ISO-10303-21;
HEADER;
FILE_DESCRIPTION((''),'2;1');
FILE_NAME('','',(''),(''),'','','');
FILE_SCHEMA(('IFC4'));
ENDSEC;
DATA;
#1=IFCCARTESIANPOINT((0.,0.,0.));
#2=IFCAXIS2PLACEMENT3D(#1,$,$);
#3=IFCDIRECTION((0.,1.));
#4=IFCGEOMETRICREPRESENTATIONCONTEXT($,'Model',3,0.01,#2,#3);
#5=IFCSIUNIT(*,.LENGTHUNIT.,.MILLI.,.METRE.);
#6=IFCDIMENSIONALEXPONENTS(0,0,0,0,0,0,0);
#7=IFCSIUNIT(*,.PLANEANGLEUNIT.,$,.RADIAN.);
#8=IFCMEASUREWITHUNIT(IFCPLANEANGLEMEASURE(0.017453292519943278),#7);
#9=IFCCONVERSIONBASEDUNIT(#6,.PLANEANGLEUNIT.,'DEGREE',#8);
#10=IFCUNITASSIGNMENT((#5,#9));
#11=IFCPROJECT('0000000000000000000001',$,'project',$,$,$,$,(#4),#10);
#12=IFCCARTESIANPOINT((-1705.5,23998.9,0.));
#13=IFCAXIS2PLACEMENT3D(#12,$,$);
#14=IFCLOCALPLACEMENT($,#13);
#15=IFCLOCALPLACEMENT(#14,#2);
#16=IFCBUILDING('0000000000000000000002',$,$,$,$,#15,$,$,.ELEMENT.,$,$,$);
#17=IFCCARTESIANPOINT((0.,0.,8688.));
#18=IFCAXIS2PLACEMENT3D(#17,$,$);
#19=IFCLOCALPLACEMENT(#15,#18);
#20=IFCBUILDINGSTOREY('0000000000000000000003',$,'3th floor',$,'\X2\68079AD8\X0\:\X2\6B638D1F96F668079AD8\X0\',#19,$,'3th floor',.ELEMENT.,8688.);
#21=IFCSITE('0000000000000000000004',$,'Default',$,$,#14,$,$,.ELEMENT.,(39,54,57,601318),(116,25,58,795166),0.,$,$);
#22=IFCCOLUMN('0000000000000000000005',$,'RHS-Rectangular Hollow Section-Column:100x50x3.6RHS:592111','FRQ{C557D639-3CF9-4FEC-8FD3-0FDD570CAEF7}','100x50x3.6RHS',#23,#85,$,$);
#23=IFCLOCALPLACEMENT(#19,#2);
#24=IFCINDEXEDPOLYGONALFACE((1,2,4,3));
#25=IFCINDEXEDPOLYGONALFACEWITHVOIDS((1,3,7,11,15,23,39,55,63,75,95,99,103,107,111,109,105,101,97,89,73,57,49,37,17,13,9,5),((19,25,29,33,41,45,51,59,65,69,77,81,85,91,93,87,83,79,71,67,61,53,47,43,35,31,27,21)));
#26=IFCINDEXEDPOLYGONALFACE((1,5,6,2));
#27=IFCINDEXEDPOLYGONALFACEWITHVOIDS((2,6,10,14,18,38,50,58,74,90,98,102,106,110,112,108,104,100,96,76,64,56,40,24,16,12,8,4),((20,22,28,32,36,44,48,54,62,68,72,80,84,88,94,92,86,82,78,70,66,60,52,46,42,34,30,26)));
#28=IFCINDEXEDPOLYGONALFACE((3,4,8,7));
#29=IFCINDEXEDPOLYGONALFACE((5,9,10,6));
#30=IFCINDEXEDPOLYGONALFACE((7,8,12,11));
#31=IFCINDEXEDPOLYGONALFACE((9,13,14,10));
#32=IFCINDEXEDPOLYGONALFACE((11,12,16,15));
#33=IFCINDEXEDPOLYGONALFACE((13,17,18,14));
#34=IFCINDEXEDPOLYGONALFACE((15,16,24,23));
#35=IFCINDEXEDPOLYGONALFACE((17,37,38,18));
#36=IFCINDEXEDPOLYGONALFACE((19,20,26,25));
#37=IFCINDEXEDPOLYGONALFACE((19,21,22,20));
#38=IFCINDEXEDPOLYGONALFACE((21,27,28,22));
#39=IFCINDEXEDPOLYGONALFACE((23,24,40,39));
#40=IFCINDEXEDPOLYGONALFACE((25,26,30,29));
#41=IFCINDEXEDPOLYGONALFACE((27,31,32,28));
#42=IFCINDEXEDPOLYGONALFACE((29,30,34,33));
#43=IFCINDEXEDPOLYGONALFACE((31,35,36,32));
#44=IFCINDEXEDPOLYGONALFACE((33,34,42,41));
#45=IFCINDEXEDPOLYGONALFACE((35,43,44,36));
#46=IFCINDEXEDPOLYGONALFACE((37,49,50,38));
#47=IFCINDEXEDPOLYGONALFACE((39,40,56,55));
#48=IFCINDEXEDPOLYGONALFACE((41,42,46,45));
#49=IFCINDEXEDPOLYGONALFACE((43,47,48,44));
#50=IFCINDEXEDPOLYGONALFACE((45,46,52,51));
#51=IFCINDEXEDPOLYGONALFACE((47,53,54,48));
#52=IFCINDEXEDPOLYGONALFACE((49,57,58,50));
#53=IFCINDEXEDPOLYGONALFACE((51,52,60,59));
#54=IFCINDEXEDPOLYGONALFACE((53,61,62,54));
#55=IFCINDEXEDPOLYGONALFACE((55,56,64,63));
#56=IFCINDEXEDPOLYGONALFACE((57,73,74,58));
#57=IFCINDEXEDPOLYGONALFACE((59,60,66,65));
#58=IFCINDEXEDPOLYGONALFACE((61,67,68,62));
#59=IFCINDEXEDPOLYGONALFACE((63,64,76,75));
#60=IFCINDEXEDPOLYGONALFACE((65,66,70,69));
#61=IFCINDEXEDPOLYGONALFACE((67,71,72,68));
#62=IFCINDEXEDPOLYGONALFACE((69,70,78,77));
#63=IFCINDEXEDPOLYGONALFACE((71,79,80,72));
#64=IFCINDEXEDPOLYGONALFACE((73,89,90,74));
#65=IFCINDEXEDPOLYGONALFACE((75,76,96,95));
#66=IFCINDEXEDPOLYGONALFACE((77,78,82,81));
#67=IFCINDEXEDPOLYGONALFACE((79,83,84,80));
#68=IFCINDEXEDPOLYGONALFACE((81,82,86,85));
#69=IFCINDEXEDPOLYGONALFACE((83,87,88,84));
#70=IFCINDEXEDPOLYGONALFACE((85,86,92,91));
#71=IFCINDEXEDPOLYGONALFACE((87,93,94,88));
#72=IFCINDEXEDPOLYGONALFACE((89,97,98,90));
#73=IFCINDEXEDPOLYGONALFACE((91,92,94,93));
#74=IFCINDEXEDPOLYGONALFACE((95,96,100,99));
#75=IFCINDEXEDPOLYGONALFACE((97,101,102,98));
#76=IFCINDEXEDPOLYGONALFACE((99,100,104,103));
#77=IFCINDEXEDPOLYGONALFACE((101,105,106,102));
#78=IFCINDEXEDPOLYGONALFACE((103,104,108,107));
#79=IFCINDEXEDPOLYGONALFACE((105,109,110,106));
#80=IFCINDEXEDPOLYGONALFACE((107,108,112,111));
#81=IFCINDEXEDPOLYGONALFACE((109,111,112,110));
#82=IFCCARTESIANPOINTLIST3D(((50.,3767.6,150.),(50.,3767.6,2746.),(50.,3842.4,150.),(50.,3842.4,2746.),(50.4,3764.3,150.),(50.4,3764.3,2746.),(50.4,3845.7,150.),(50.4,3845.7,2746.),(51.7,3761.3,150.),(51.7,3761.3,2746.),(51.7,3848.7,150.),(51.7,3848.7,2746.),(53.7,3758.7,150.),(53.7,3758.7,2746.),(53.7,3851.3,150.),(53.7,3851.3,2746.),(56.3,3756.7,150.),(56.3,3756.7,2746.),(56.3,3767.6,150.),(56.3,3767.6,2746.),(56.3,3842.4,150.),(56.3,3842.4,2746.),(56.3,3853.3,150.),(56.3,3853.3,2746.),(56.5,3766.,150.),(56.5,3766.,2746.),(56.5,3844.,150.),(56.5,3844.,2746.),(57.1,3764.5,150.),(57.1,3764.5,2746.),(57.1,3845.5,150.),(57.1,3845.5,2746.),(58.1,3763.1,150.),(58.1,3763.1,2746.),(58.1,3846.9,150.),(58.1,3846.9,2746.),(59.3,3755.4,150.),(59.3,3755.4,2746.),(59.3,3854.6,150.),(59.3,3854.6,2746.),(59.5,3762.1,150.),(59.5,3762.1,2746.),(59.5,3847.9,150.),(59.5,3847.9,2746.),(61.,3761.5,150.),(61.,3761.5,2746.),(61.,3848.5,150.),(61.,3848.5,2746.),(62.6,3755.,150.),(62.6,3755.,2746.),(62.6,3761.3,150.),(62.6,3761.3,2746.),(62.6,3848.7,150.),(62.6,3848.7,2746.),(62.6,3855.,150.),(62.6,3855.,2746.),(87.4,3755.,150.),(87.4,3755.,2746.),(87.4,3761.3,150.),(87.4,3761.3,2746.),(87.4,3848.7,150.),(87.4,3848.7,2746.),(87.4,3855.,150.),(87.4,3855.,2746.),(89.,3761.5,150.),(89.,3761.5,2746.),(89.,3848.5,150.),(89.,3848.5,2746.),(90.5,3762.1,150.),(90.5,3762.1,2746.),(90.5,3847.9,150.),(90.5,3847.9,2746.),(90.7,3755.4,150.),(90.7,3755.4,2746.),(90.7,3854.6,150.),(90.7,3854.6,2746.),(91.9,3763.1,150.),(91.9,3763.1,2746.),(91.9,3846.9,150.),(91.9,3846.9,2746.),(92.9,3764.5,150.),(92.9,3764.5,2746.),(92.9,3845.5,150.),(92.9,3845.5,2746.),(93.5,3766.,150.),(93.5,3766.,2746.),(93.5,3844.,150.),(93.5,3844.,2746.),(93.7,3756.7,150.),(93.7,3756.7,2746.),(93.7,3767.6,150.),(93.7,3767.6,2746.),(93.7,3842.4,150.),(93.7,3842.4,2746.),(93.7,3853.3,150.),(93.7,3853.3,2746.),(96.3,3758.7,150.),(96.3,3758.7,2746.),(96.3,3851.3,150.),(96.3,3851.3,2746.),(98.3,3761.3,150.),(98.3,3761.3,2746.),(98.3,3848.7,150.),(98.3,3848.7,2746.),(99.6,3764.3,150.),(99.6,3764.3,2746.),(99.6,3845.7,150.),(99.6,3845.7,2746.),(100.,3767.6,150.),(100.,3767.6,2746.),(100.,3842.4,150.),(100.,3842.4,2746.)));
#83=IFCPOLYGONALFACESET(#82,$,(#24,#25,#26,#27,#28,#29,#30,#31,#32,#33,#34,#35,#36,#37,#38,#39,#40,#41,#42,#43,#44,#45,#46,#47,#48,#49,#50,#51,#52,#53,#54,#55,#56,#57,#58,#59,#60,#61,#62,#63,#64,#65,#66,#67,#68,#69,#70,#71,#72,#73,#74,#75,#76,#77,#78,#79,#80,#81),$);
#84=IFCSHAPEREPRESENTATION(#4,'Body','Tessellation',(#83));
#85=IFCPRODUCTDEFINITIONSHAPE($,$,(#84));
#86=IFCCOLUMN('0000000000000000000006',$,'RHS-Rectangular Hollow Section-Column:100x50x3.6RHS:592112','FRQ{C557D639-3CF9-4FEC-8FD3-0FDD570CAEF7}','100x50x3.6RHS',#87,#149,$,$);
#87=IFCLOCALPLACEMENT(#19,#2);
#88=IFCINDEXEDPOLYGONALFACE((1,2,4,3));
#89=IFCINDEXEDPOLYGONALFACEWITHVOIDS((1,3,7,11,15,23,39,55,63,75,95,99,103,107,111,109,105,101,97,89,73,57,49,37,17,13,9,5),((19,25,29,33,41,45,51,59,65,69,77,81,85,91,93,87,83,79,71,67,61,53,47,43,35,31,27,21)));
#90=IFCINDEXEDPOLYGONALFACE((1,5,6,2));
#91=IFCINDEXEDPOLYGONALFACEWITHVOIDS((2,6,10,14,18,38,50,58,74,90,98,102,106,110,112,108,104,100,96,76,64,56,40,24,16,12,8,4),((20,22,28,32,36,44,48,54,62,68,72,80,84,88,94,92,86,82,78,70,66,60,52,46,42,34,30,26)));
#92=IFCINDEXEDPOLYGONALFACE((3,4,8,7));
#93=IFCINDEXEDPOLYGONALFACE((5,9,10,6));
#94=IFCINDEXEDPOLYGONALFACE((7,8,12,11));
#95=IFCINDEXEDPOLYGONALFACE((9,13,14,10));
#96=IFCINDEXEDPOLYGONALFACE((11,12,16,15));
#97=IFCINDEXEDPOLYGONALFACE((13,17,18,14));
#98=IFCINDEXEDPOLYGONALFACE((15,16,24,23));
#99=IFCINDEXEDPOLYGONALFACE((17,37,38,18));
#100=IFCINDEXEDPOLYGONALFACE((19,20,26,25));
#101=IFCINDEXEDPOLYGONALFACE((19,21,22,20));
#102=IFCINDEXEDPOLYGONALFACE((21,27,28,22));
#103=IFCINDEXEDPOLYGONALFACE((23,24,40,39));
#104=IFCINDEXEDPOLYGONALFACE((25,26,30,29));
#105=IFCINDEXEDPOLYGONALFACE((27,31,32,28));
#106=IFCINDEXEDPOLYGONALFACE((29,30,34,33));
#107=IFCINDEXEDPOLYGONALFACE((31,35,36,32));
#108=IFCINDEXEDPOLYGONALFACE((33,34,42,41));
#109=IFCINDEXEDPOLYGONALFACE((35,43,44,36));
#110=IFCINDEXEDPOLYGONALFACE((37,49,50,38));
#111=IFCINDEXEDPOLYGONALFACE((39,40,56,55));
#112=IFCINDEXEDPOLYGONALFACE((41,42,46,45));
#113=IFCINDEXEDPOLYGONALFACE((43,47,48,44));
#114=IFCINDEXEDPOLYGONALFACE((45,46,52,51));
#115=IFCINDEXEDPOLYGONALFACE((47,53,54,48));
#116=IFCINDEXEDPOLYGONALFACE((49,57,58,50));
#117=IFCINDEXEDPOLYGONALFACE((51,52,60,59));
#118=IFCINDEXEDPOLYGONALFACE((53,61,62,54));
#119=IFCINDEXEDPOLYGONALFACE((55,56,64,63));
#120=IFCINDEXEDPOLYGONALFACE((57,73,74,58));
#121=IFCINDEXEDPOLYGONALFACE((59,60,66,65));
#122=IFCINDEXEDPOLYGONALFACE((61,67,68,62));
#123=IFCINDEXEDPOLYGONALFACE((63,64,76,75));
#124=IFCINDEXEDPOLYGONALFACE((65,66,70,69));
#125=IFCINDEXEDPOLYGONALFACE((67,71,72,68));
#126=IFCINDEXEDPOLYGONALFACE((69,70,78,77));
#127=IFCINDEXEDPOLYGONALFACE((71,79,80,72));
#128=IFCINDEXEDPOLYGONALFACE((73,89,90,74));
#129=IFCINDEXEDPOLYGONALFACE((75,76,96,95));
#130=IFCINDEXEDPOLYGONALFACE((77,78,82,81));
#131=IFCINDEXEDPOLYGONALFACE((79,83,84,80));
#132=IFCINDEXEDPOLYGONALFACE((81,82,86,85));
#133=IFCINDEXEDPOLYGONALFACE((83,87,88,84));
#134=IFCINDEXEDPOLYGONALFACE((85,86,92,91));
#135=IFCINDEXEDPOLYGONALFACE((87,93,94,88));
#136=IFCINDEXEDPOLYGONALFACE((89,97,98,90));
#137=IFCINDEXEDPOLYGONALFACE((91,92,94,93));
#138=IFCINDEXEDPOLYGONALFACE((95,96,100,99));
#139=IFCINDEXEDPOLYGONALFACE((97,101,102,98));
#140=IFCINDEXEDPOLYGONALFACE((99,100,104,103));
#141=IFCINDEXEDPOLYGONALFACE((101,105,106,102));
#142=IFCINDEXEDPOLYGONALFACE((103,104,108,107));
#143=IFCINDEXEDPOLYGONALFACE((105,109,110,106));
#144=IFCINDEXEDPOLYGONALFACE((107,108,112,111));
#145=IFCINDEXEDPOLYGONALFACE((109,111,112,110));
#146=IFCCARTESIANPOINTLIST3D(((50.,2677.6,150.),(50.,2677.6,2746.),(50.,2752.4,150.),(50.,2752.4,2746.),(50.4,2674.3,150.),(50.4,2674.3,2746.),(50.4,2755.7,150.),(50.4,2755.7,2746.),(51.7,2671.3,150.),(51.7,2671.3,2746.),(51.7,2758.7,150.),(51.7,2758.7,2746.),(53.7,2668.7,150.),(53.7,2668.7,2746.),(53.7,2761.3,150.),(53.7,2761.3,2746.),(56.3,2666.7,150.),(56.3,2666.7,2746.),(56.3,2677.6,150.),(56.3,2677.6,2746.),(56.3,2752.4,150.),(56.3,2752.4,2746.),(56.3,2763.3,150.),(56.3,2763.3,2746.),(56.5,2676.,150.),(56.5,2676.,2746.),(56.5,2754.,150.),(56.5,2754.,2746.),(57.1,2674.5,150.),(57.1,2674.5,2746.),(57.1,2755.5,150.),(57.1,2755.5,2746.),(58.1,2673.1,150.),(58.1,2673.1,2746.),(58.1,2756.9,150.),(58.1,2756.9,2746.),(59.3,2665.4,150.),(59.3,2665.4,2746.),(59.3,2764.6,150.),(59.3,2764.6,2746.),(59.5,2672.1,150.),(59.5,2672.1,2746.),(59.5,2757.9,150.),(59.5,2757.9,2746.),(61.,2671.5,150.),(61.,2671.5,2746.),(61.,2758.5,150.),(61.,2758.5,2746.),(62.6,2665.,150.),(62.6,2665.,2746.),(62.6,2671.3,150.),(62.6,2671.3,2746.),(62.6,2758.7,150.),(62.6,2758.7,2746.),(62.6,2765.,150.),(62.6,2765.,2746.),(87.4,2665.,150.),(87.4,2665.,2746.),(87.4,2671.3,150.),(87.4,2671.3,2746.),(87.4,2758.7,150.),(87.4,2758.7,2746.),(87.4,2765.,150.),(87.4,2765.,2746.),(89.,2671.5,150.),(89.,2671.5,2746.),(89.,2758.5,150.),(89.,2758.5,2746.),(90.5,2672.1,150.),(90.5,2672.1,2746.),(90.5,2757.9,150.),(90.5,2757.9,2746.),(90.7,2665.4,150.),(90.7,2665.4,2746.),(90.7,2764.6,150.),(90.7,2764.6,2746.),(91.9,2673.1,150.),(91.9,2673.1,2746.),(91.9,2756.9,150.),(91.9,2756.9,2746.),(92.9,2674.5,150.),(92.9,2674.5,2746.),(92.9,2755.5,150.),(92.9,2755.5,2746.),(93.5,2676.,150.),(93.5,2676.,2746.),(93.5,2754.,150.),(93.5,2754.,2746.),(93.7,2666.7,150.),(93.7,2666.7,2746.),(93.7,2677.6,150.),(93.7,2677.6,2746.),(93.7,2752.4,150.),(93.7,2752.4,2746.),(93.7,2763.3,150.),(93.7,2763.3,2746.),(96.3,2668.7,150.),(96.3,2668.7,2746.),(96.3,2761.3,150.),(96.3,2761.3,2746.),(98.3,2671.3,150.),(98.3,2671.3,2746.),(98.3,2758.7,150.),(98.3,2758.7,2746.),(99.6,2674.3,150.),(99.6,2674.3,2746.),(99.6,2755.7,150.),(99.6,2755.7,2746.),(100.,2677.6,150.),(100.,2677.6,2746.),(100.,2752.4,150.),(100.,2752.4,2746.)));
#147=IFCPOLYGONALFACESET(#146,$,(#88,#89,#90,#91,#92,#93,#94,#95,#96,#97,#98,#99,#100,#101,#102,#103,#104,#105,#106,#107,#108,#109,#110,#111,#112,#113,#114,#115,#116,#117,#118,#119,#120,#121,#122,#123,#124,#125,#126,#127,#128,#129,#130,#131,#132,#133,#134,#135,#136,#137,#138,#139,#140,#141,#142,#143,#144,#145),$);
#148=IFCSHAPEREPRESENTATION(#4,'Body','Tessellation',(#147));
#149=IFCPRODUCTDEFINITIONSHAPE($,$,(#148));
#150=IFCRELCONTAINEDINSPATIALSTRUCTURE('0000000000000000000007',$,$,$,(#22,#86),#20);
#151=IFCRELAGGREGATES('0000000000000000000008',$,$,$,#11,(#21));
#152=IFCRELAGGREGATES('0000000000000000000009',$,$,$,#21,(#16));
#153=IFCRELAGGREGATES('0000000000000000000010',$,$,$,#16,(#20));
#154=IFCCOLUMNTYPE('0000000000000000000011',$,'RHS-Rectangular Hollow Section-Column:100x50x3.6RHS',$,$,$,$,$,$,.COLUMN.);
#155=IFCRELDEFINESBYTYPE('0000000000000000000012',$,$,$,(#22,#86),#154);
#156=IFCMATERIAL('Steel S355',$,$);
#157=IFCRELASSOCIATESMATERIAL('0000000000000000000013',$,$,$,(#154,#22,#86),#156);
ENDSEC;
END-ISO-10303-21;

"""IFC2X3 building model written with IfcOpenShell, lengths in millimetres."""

from ifc_helpers import new_model, entity, si_unit, converted_unit, point, direction, frame, frame_2d, origin, origin_2d, place, context, project, spatial, circle_curve, line_curve, trimmed, segment, composite_curve, hollow_rectangle, outline, extrude, clip, halfspace, material, type_object, element, save


model = new_model("IFC2X3")

# Units and contexts
model_context = context("Model", 3, precision=0.01, world=origin(), true_north=direction((0.0, 1.0)))
ifc_project = project(units=[si_unit("LENGTHUNIT", "METRE", prefix="MILLI"), converted_unit("PLANEANGLEUNIT", "DEGREE", entity("IfcPlaneAngleMeasure", 0.017453292519943278), si_unit("PLANEANGLEUNIT", "RADIAN"), dimensions=[0, 0, 0, 0, 0, 0, 0])], contexts=[model_context])

# Site, building, storey
site_placement = place(None, frame((-1705.5, 23998.9, 0.0)))
site = spatial("IfcSite", under=ifc_project, at=site_placement, Name="Default", CompositionType="ELEMENT", RefLatitude=(39, 54, 57, 601318), RefLongitude=(116, 25, 58, 795166), RefElevation=0.0)
building_placement = place(site_placement, origin())
building = spatial("IfcBuilding", under=site, at=building_placement, CompositionType="ELEMENT")
storey_placement = place(building_placement, frame((0.0, 0.0, 8688.0)))
storey = spatial("IfcBuildingStorey", under=building, at=storey_placement, Name="3th floor", ObjectType="标高:正负零标高", LongName="3th floor", CompositionType="ELEMENT", Elevation=8688.0)

# Columns, openings
ifc_material_1 = material(Name="Steel S355")
column_type_1 = type_object("IfcColumnType", Name="RHS-Rectangular Hollow Section-Column:100x50x3.6RHS", PredefinedType="COLUMN", material=ifc_material_1)
column_1_placement = place(storey_placement, frame((75.0, 3805.0, 2876.9)))
column_1 = element("IfcColumn", 1, at=column_1_placement, inside=storey, type_object=column_type_1, material=ifc_material_1, Name="RHS-Rectangular Hollow Section-Column:100x50x3.6RHS:592111", Description="FRQ{C557D639-3CF9-4FEC-8FD3-0FDD570CAEF7}", ObjectType="100x50x3.6RHS", context=model_context, shape_type="Clipping", body=[
    clip(clip(extrude(hollow_rectangle(XDim=50.0, YDim=100.0, WallThickness=6.3, InnerFilletRadius=6.3, OuterFilletRadius=12.6, at=origin_2d()), origin(), (0.0, 0.0, -1.0), 2782.8), halfspace(frame((-75.0, -3805.0, -55.9), z_axis=(0.0, 0.0, -1.0), x_axis=(-1.0, 0.0, 0.0)), True)), halfspace(frame((-75.0, -3805.0, -2726.9), z_axis=(0.0, 0.0, 1.0), x_axis=(1.0, 0.0, 0.0)), True)),
])
opening_1_placement = place(column_1_placement, frame((0.0, -150.1, -130.9), z_axis=(0.0, 1.0, 0.0), x_axis=(-1.0, 0.0, 0.0)))
element("IfcOpeningElement", 2, at=opening_1_placement, cuts=column_1, ObjectType="Opening", context=model_context, shape_type="SweptSolid", body=[
    extrude(outline(composite_curve([segment(trimmed(circle_curve(frame_2d((43.0, 32.0), x_axis=(1.0, 0.0)), 32.0), [point((43.0, 0.0))], [point((75.0, 32.0))], True, "CARTESIAN"), True, "CONTINUOUS"), segment(trimmed(line_curve((75.0, 32.0), (0.0, 1.0), 86.0), [point((75.0, 32.0))], [point((75.0, 118.0))], True, "CARTESIAN"), True, "CONTINUOUS"), segment(trimmed(circle_curve(frame_2d((43.0, 118.0), x_axis=(1.0, 0.0)), 32.0), [point((75.0, 118.0))], [point((43.0, 150.0))], True, "CARTESIAN"), True, "CONTINUOUS"), segment(trimmed(line_curve((43.0, 150.0), (-1.0, 0.0), 86.0), [point((43.0, 150.0))], [point((-43.0, 150.0))], True, "CARTESIAN"), True, "CONTINUOUS"), segment(trimmed(circle_curve(frame_2d((-43.0, 118.0), x_axis=(1.0, 0.0)), 32.0), [point((-43.0, 150.0))], [point((-75.0, 118.0))], True, "CARTESIAN"), True, "CONTINUOUS"), segment(trimmed(line_curve((-75.0, 118.0), (0.0, -1.0), 86.0), [point((-75.0, 118.0))], [point((-75.0, 32.0))], True, "CARTESIAN"), True, "CONTINUOUS"), segment(trimmed(circle_curve(frame_2d((-43.0, 32.0), x_axis=(1.0, 0.0)), 32.0), [point((-75.0, 32.0))], [point((-43.0, 0.0))], True, "CARTESIAN"), True, "CONTINUOUS"), segment(trimmed(line_curve((-43.0, 0.0), (1.0, 0.0), 86.0), [point((-43.0, 0.0))], [point((43.0, 0.0))], True, "CARTESIAN"), True, "CONTINUOUS")], self_intersect="UNKNOWN")), origin(), (0.0, 0.0, 1.0), 300.2),
])
column_2_placement = place(storey_placement, frame((75.0, 2715.0, 2876.9)))
column_2 = element("IfcColumn", 3, at=column_2_placement, inside=storey, type_object=column_type_1, material=ifc_material_1, Name="RHS-Rectangular Hollow Section-Column:100x50x3.6RHS:592112", Description="FRQ{C557D639-3CF9-4FEC-8FD3-0FDD570CAEF7}", ObjectType="100x50x3.6RHS", context=model_context, shape_type="Clipping", body=[
    clip(clip(extrude(hollow_rectangle(XDim=50.0, YDim=100.0, WallThickness=6.3, InnerFilletRadius=6.3, OuterFilletRadius=12.6, at=origin_2d()), origin(), (0.0, 0.0, -1.0), 2782.8), halfspace(frame((-75.0, -2715.0, -55.9), z_axis=(0.0, 0.0, -1.0), x_axis=(-1.0, 0.0, 0.0)), True)), halfspace(frame((-75.0, -2715.0, -2726.9), z_axis=(0.0, 0.0, 1.0), x_axis=(1.0, 0.0, 0.0)), True)),
])
opening_2_placement = place(column_2_placement, frame((0.0, -150.1, -130.9), z_axis=(0.0, 1.0, 0.0), x_axis=(-1.0, 0.0, 0.0)))
element("IfcOpeningElement", 4, at=opening_2_placement, cuts=column_2, ObjectType="Opening", context=model_context, shape_type="SweptSolid", body=[
    extrude(outline(composite_curve([segment(trimmed(circle_curve(frame_2d((43.0, 32.0), x_axis=(1.0, 0.0)), 32.0), [point((43.0, 0.0))], [point((75.0, 32.0))], True, "CARTESIAN"), True, "CONTINUOUS"), segment(trimmed(line_curve((75.0, 32.0), (0.0, 1.0), 86.0), [point((75.0, 32.0))], [point((75.0, 118.0))], True, "CARTESIAN"), True, "CONTINUOUS"), segment(trimmed(circle_curve(frame_2d((43.0, 118.0), x_axis=(1.0, 0.0)), 32.0), [point((75.0, 118.0))], [point((43.0, 150.0))], True, "CARTESIAN"), True, "CONTINUOUS"), segment(trimmed(line_curve((43.0, 150.0), (-1.0, 0.0), 86.0), [point((43.0, 150.0))], [point((-43.0, 150.0))], True, "CARTESIAN"), True, "CONTINUOUS"), segment(trimmed(circle_curve(frame_2d((-43.0, 118.0), x_axis=(1.0, 0.0)), 32.0), [point((-43.0, 150.0))], [point((-75.0, 118.0))], True, "CARTESIAN"), True, "CONTINUOUS"), segment(trimmed(line_curve((-75.0, 118.0), (0.0, -1.0), 86.0), [point((-75.0, 118.0))], [point((-75.0, 32.0))], True, "CARTESIAN"), True, "CONTINUOUS"), segment(trimmed(circle_curve(frame_2d((-43.0, 32.0), x_axis=(1.0, 0.0)), 32.0), [point((-75.0, 32.0))], [point((-43.0, 0.0))], True, "CARTESIAN"), True, "CONTINUOUS"), segment(trimmed(line_curve((-43.0, 0.0), (1.0, 0.0), 86.0), [point((-43.0, 0.0))], [point((43.0, 0.0))], True, "CARTESIAN"), True, "CONTINUOUS")], self_intersect="UNKNOWN")), origin(), (0.0, 0.0, 1.0), 300.2),
])

save(model, "model.ifc")
